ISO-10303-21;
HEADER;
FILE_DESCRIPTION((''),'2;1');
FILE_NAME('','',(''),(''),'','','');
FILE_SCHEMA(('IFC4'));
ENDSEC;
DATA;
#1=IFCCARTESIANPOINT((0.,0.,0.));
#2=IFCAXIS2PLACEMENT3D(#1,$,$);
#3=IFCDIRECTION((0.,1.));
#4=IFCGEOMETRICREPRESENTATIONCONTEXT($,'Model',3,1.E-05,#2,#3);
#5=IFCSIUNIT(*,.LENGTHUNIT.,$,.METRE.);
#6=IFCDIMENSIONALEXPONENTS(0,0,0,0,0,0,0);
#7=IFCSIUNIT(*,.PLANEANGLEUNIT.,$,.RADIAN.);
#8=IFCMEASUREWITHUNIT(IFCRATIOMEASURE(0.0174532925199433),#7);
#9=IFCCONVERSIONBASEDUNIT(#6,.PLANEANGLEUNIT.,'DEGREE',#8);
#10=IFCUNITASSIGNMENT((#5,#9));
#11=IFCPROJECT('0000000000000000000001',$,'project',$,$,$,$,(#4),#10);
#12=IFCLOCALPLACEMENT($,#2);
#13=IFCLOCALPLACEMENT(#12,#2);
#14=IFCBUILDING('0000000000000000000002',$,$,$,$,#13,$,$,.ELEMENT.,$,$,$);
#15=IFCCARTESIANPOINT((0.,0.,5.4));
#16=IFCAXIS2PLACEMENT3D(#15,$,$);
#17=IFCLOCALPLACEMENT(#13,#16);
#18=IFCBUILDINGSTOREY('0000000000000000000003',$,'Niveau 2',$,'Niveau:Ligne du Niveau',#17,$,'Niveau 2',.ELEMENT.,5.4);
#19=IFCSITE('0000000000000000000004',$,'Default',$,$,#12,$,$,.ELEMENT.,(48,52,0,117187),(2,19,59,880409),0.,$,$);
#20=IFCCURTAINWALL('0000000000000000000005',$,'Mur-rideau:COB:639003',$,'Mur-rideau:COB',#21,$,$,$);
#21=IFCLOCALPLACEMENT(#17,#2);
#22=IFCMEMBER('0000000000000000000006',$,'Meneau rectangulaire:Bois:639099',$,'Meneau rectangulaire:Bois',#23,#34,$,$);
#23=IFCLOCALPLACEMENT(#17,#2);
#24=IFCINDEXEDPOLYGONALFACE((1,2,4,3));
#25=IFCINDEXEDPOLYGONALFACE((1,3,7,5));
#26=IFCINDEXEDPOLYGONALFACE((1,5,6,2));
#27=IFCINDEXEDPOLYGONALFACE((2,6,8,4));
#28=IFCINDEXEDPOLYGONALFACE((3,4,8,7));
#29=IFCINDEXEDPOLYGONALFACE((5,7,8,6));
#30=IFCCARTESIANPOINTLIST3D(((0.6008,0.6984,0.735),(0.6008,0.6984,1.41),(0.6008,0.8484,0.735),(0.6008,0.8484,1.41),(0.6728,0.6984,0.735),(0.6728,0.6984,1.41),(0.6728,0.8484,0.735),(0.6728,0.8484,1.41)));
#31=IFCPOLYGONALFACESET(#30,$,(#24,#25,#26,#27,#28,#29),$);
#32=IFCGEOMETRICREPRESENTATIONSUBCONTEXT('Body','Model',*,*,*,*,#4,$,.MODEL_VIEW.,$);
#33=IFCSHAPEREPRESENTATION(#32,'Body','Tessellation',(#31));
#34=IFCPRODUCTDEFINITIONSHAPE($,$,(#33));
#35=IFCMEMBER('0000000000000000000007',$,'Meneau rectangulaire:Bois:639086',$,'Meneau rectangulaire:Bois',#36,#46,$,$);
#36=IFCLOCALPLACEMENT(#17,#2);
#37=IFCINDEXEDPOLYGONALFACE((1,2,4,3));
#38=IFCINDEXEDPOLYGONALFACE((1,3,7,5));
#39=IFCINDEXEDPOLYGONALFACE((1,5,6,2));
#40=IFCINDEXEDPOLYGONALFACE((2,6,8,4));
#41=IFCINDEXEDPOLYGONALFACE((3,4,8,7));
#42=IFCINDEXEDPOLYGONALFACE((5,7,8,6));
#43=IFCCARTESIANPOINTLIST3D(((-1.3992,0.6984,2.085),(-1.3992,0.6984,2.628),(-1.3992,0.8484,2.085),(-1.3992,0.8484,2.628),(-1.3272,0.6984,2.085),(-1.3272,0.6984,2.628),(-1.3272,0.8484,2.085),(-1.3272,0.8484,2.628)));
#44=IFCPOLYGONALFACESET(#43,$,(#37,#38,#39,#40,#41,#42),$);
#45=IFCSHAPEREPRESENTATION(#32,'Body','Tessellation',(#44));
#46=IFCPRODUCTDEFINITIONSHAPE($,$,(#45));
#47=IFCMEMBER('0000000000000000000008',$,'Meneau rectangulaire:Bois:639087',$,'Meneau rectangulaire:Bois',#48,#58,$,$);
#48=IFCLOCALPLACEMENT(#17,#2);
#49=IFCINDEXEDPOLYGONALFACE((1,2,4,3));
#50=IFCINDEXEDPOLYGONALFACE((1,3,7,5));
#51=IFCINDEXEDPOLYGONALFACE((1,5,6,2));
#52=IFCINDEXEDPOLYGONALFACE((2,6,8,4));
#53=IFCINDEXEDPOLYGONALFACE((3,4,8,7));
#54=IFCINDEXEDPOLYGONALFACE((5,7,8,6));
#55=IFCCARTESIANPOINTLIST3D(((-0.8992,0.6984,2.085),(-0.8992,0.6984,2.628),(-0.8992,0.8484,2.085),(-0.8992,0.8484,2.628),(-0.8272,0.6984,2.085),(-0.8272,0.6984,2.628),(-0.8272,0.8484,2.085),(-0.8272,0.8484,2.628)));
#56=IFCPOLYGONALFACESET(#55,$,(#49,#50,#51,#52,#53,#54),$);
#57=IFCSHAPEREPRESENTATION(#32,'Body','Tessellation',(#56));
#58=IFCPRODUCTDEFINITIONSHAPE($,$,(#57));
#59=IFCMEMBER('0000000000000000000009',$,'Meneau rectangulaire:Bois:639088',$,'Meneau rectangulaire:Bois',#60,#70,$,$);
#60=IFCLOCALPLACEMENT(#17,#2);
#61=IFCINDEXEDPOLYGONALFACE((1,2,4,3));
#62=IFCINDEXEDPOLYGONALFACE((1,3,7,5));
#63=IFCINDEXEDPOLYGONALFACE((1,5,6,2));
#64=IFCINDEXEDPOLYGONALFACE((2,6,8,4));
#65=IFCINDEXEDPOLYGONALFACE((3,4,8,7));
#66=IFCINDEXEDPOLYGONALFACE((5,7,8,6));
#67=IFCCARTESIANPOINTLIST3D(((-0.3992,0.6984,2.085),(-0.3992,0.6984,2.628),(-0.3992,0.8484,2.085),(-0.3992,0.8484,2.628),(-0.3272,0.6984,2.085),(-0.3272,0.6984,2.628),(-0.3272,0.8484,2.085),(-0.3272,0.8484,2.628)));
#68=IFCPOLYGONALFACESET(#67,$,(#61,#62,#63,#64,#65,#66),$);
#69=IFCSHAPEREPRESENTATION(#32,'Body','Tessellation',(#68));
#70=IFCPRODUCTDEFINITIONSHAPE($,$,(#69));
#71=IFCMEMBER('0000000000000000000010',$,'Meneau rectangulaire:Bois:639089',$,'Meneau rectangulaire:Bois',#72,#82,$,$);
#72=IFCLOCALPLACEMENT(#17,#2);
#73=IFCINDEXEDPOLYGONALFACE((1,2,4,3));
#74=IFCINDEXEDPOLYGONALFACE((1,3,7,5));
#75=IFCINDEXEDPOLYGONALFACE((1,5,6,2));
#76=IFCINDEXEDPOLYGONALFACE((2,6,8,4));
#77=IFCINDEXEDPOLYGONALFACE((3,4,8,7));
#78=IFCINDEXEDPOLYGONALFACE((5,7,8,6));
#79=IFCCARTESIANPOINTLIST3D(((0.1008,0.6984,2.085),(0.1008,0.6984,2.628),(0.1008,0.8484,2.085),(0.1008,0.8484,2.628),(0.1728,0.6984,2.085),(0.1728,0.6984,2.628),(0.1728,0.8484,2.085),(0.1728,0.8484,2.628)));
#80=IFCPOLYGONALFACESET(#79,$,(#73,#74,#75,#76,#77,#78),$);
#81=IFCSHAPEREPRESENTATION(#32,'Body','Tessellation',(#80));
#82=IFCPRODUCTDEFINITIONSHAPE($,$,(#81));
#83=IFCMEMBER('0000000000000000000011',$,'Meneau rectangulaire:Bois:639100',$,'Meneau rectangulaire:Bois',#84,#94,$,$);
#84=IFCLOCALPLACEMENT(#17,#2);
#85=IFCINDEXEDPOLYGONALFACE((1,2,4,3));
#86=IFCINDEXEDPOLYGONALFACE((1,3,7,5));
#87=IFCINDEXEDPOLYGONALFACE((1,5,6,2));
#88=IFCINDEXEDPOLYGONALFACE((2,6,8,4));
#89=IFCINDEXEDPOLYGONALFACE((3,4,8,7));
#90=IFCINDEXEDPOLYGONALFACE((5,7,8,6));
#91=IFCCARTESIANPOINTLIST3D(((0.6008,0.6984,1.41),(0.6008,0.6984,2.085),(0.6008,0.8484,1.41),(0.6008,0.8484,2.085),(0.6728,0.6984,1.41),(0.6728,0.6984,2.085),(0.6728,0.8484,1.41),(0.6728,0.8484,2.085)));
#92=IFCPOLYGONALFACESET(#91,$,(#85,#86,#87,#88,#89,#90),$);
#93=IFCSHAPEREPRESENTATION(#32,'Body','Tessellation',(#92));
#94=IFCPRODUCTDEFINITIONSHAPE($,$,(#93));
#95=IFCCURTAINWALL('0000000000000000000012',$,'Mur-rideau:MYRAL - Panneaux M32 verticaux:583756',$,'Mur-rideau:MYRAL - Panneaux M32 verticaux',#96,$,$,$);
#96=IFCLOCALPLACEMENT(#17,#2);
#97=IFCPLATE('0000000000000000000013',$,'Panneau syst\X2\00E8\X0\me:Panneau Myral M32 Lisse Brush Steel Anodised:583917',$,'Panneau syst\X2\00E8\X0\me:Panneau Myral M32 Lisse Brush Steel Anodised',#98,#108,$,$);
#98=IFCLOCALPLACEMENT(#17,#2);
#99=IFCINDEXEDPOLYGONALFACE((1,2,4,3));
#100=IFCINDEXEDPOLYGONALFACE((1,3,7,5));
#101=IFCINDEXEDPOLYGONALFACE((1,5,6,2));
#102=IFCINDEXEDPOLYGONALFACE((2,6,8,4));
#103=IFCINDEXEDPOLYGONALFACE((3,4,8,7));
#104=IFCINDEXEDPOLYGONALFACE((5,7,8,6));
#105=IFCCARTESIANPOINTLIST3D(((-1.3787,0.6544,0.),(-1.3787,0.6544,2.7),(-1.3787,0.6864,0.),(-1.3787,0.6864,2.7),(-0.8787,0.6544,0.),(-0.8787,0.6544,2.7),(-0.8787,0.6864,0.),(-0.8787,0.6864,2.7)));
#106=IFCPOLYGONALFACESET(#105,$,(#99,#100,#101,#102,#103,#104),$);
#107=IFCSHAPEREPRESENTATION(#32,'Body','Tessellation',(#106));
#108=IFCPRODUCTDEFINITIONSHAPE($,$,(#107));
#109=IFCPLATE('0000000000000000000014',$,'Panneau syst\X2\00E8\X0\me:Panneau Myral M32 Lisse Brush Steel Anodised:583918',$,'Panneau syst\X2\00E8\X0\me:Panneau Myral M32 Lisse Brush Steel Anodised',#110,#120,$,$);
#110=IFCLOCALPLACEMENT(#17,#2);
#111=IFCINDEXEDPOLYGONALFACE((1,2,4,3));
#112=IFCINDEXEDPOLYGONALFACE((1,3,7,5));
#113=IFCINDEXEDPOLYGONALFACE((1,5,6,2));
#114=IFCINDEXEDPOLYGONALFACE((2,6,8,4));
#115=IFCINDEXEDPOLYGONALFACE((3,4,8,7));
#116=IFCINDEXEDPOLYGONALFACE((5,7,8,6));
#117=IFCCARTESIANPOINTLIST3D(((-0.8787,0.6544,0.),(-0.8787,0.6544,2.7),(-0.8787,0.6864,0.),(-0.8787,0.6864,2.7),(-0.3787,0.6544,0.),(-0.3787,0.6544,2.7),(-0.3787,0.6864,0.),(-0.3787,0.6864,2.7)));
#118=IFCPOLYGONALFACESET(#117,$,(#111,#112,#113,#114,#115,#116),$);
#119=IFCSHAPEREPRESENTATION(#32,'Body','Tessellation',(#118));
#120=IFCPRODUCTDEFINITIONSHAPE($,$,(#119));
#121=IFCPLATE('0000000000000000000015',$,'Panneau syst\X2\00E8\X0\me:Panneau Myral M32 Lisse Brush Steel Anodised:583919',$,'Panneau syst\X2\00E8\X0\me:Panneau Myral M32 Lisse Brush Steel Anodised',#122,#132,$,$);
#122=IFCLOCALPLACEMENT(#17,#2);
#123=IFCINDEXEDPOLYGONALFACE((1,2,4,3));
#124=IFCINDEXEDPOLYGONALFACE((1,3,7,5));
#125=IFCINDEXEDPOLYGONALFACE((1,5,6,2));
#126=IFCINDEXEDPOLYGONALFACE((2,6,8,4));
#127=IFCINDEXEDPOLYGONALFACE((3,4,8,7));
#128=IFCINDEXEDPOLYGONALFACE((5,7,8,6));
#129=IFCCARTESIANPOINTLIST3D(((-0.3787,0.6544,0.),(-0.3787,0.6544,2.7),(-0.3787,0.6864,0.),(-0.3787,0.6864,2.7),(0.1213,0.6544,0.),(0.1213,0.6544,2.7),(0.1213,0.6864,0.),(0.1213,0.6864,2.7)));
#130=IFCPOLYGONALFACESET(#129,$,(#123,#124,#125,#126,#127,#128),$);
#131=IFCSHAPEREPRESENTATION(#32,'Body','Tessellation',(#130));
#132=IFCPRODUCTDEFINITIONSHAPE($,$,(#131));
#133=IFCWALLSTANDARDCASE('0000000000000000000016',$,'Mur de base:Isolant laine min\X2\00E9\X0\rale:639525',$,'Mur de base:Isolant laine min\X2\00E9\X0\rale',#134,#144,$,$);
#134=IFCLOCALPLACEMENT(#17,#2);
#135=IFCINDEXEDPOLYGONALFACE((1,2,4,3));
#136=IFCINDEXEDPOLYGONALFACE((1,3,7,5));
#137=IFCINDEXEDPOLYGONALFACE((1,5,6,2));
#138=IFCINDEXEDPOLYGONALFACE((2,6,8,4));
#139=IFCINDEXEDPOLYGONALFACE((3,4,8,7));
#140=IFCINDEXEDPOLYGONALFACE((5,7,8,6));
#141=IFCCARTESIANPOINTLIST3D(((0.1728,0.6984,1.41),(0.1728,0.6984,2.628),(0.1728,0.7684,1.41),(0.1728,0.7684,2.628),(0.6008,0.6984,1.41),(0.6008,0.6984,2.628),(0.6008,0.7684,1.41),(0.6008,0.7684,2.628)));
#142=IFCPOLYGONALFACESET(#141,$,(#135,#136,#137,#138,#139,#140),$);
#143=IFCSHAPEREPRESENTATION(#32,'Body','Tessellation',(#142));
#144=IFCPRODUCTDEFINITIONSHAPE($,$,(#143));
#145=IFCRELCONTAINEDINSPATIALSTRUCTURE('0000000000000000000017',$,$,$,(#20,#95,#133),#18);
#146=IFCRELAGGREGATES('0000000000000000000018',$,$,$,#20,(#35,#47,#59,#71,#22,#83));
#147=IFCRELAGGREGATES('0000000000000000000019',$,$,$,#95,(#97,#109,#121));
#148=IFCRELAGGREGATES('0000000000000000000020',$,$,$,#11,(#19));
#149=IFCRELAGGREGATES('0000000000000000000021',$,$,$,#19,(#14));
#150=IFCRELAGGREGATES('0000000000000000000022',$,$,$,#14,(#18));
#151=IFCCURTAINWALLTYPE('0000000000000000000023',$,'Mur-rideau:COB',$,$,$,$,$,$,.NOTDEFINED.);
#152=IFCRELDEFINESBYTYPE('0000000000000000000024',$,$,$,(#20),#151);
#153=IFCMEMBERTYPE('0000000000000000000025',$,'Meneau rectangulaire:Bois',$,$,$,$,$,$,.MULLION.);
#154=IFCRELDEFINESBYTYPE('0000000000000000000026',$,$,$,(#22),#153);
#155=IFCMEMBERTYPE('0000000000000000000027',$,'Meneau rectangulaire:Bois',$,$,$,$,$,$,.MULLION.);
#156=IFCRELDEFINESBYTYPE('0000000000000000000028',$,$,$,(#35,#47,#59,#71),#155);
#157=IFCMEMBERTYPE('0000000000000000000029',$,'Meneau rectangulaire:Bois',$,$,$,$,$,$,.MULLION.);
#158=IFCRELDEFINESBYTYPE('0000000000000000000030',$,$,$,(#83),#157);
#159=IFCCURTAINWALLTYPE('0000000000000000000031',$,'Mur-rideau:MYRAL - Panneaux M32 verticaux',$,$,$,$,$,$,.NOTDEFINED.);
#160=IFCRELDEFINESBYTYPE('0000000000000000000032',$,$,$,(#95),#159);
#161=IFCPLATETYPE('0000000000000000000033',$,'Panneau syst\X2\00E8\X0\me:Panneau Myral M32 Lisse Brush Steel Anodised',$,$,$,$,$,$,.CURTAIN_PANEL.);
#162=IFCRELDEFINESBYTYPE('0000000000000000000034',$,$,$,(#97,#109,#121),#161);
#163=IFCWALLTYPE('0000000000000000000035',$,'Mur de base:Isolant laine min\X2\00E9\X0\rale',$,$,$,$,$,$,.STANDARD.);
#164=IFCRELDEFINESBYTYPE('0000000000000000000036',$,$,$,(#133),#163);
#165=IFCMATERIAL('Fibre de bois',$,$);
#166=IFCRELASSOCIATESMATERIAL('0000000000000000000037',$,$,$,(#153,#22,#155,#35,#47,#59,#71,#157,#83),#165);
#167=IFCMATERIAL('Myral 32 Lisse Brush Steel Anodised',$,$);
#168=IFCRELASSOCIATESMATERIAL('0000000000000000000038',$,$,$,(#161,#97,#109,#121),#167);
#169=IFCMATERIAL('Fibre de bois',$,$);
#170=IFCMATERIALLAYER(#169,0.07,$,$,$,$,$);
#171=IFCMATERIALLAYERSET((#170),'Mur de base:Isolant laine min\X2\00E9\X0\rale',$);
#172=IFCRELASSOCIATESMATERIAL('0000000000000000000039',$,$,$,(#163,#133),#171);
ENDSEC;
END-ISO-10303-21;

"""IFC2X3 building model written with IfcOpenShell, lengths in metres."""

from ifc_helpers import new_model, entity, si_unit, converted_unit, direction, frame, frame_2d, origin, origin_2d_with_axis, place, context, subcontext, project, spatial, rectangle, extrude, source, transform, mapped, material, layer, layer_set, layer_usage, type_object, type_shapes, element, aggregate, save


model = new_model("IFC2X3")

# Units and contexts
model_context = context("Model", 3, precision=1e-05, world=origin(), true_north=direction((0.0, 1.0)))
body_context = subcontext(model_context, "Body", "Model", "MODEL_VIEW")
ifc_project = project(units=[si_unit("LENGTHUNIT", "METRE"), converted_unit("PLANEANGLEUNIT", "DEGREE", entity("IfcRatioMeasure", 0.0174532925199433), si_unit("PLANEANGLEUNIT", "RADIAN"), dimensions=[0, 0, 0, 0, 0, 0, 0])], contexts=[model_context])

# Site, building, storey
site_placement = place(None, origin())
site = spatial("IfcSite", under=ifc_project, at=site_placement, Name="Default", CompositionType="ELEMENT", RefLatitude=(48, 52, 0, 117187), RefLongitude=(2, 19, 59, 880409), RefElevation=0.0)
building_placement = place(site_placement, origin())
building = spatial("IfcBuilding", under=site, at=building_placement, CompositionType="ELEMENT")
storey_placement = place(building_placement, frame((0.0, 0.0, 5.4)))
storey = spatial("IfcBuildingStorey", under=building, at=storey_placement, Name="Niveau 2", ObjectType="Niveau:Ligne du Niveau", LongName="Niveau 2", CompositionType="ELEMENT", Elevation=5.4)

# Curtain wall, members
curtain_wall_type_1 = type_object("IfcCurtainWallType", Name="Mur-rideau:COB", PredefinedType="NOTDEFINED")
curtain_wall_1_placement = place(storey_placement, frame((0.0, 0.0, -5.4)))
curtain_wall_1 = element("IfcCurtainWall", 1, at=curtain_wall_1_placement, inside=storey, type_object=curtain_wall_type_1, Name="Mur-rideau:COB:639003", ObjectType="Mur-rideau:COB")
ifc_material_1 = material(Name="Fibre de bois")
member_type_1 = type_object("IfcMemberType", Name="Meneau rectangulaire:Bois", PredefinedType="MULLION", material=ifc_material_1)
shared_shape_1 = source(origin(), body_context, "Body", "SweptSolid", [
    extrude(rectangle(XDim=0.15, YDim=0.072, at=origin_2d_with_axis()), frame((-0.024, 0.0, -0.675), z_axis=(0.0, 0.0, 1.0), x_axis=(0.0, -1.0, 0.0)), (0.0, 0.0, 1.0), 0.675),
])
type_shapes(member_type_1, [shared_shape_1])
member_1_placement = place(storey_placement, frame((0.6608, 0.7734, 0.735), z_axis=(0.0, 0.0, -1.0), x_axis=(1.0, 0.0, 0.0)))
member_1 = element("IfcMember", 2, at=member_1_placement, type_object=member_type_1, material=ifc_material_1, Name="Meneau rectangulaire:Bois:639099", ObjectType="Meneau rectangulaire:Bois", context=body_context, shape_type="MappedRepresentation", body=[
    mapped(shared_shape_1, transform((0.0, 0.0, 0.0), scale=1.0)),
])
member_type_2 = type_object("IfcMemberType", Name="Meneau rectangulaire:Bois", PredefinedType="MULLION", material=ifc_material_1)
shared_shape_2 = source(origin(), body_context, "Body", "SweptSolid", [
    extrude(rectangle(XDim=0.15, YDim=0.072, at=origin_2d_with_axis()), frame((-0.024, 0.0, -0.543), z_axis=(0.0, 0.0, 1.0), x_axis=(0.0, -1.0, 0.0)), (0.0, 0.0, 1.0), 0.543),
])
type_shapes(member_type_2, [shared_shape_2])
member_2_placement = place(storey_placement, frame((-1.3392, 0.7734, 2.085), z_axis=(0.0, 0.0, -1.0), x_axis=(1.0, 0.0, 0.0)))
member_2 = element("IfcMember", 3, at=member_2_placement, type_object=member_type_2, material=ifc_material_1, Name="Meneau rectangulaire:Bois:639086", ObjectType="Meneau rectangulaire:Bois", context=body_context, shape_type="MappedRepresentation", body=[
    mapped(shared_shape_2, transform((0.0, 0.0, 0.0), scale=1.0)),
])
member_3_placement = place(storey_placement, frame((-0.8392, 0.7734, 2.085), z_axis=(0.0, 0.0, -1.0), x_axis=(1.0, 0.0, 0.0)))
member_3 = element("IfcMember", 4, at=member_3_placement, type_object=member_type_2, material=ifc_material_1, Name="Meneau rectangulaire:Bois:639087", ObjectType="Meneau rectangulaire:Bois", context=body_context, shape_type="MappedRepresentation", body=[
    mapped(shared_shape_2, transform((0.0, 0.0, 0.0), scale=1.0)),
])
member_4_placement = place(storey_placement, frame((-0.3392, 0.7734, 2.085), z_axis=(0.0, 0.0, -1.0), x_axis=(1.0, 0.0, 0.0)))
member_4 = element("IfcMember", 5, at=member_4_placement, type_object=member_type_2, material=ifc_material_1, Name="Meneau rectangulaire:Bois:639088", ObjectType="Meneau rectangulaire:Bois", context=body_context, shape_type="MappedRepresentation", body=[
    mapped(shared_shape_2, transform((0.0, 0.0, 0.0), scale=1.0)),
])
member_5_placement = place(storey_placement, frame((0.1608, 0.7734, 2.085), z_axis=(0.0, 0.0, -1.0), x_axis=(1.0, 0.0, 0.0)))
member_5 = element("IfcMember", 6, at=member_5_placement, type_object=member_type_2, material=ifc_material_1, Name="Meneau rectangulaire:Bois:639089", ObjectType="Meneau rectangulaire:Bois", context=body_context, shape_type="MappedRepresentation", body=[
    mapped(shared_shape_2, transform((0.0, 0.0, 0.0), scale=1.0)),
])
member_type_3 = type_object("IfcMemberType", Name="Meneau rectangulaire:Bois", PredefinedType="MULLION", material=ifc_material_1)
shared_shape_3 = source(origin(), body_context, "Body", "SweptSolid", [
    extrude(rectangle(XDim=0.15, YDim=0.072, at=origin_2d_with_axis()), frame((-0.024, 0.0, -0.675), z_axis=(0.0, 0.0, 1.0), x_axis=(0.0, -1.0, 0.0)), (0.0, 0.0, 1.0), 0.675),
])
type_shapes(member_type_3, [shared_shape_3])
member_6_placement = place(storey_placement, frame((0.6608, 0.7734, 1.41), z_axis=(0.0, 0.0, -1.0), x_axis=(1.0, 0.0, 0.0)))
member_6 = element("IfcMember", 7, at=member_6_placement, type_object=member_type_3, material=ifc_material_1, Name="Meneau rectangulaire:Bois:639100", ObjectType="Meneau rectangulaire:Bois", context=body_context, shape_type="MappedRepresentation", body=[
    mapped(shared_shape_3, transform((0.0, 0.0, 0.0), scale=1.0)),
])
aggregate(curtain_wall_1, [member_2, member_3, member_4, member_5, member_1, member_6])

# Curtain wall, plates
curtain_wall_type_2 = type_object("IfcCurtainWallType", Name="Mur-rideau:MYRAL - Panneaux M32 verticaux", PredefinedType="NOTDEFINED")
curtain_wall_2_placement = place(storey_placement, frame((0.0, 0.0, -5.4)))
curtain_wall_2 = element("IfcCurtainWall", 8, at=curtain_wall_2_placement, inside=storey, type_object=curtain_wall_type_2, Name="Mur-rideau:MYRAL - Panneaux M32 verticaux:583756", ObjectType="Mur-rideau:MYRAL - Panneaux M32 verticaux")
ifc_material_2 = material(Name="Myral 32 Lisse Brush Steel Anodised")
plate_type = type_object("IfcPlateType", Name="Panneau système:Panneau Myral M32 Lisse Brush Steel Anodised", PredefinedType="CURTAIN_PANEL", material=ifc_material_2)
shared_shape_4 = source(origin(), body_context, "Body", "SweptSolid", [
    extrude(rectangle(XDim=0.032, YDim=0.5, at=origin_2d_with_axis()), frame((0.0, -0.016, 0.0), z_axis=(0.0, 0.0, 1.0), x_axis=(0.0, 1.0, 0.0)), (0.0, 0.0, 1.0), 2.7),
])
type_shapes(plate_type, [shared_shape_4])
plate_1_placement = place(curtain_wall_2_placement, frame((-1.1287, 0.6864, 5.4)))
plate_1 = element("IfcPlate", 9, at=plate_1_placement, type_object=plate_type, material=ifc_material_2, Name="Panneau système:Panneau Myral M32 Lisse Brush Steel Anodised:583917", ObjectType="Panneau système:Panneau Myral M32 Lisse Brush Steel Anodised", context=body_context, shape_type="MappedRepresentation", body=[
    mapped(shared_shape_4, transform((0.0, 0.0, 0.0), scale=1.0)),
])
plate_2_placement = place(curtain_wall_2_placement, frame((-0.6287, 0.6864, 5.4)))
plate_2 = element("IfcPlate", 10, at=plate_2_placement, type_object=plate_type, material=ifc_material_2, Name="Panneau système:Panneau Myral M32 Lisse Brush Steel Anodised:583918", ObjectType="Panneau système:Panneau Myral M32 Lisse Brush Steel Anodised", context=body_context, shape_type="MappedRepresentation", body=[
    mapped(shared_shape_4, transform((0.0, 0.0, 0.0), scale=1.0)),
])
plate_3_placement = place(curtain_wall_2_placement, frame((-0.1287, 0.6864, 5.4)))
plate_3 = element("IfcPlate", 11, at=plate_3_placement, type_object=plate_type, material=ifc_material_2, Name="Panneau système:Panneau Myral M32 Lisse Brush Steel Anodised:583919", ObjectType="Panneau système:Panneau Myral M32 Lisse Brush Steel Anodised", context=body_context, shape_type="MappedRepresentation", body=[
    mapped(shared_shape_4, transform((0.0, 0.0, 0.0), scale=1.0)),
])
aggregate(curtain_wall_2, [plate_1, plate_2, plate_3])

# Wall
ifc_material_3 = material(Name="Fibre de bois")
ifc_layer = layer(ifc_material_3, 0.07)
ifc_layer_set = layer_set([ifc_layer], Name="Mur de base:Isolant laine minérale")
ifc_layer_usage = layer_usage(ifc_layer_set, "AXIS2", "NEGATIVE", 0.035)
wall_type = type_object("IfcWallType", Name="Mur de base:Isolant laine minérale", PredefinedType="STANDARD", material=ifc_layer_set)
wall_placement = place(storey_placement, frame((0.1728, 0.7334, 1.41)))
element("IfcWallStandardCase", 12, at=wall_placement, inside=storey, type_object=wall_type, material=ifc_layer_usage, Name="Mur de base:Isolant laine minérale:639525", ObjectType="Mur de base:Isolant laine minérale", context=body_context, shape_type="SweptSolid", body=[
    extrude(rectangle(XDim=0.428, YDim=0.07, at=frame_2d((0.214, 0.0), x_axis=(-1.0, 0.0))), origin(), (0.0, 0.0, 1.0), 1.218),
])

save(model, "model.ifc")
